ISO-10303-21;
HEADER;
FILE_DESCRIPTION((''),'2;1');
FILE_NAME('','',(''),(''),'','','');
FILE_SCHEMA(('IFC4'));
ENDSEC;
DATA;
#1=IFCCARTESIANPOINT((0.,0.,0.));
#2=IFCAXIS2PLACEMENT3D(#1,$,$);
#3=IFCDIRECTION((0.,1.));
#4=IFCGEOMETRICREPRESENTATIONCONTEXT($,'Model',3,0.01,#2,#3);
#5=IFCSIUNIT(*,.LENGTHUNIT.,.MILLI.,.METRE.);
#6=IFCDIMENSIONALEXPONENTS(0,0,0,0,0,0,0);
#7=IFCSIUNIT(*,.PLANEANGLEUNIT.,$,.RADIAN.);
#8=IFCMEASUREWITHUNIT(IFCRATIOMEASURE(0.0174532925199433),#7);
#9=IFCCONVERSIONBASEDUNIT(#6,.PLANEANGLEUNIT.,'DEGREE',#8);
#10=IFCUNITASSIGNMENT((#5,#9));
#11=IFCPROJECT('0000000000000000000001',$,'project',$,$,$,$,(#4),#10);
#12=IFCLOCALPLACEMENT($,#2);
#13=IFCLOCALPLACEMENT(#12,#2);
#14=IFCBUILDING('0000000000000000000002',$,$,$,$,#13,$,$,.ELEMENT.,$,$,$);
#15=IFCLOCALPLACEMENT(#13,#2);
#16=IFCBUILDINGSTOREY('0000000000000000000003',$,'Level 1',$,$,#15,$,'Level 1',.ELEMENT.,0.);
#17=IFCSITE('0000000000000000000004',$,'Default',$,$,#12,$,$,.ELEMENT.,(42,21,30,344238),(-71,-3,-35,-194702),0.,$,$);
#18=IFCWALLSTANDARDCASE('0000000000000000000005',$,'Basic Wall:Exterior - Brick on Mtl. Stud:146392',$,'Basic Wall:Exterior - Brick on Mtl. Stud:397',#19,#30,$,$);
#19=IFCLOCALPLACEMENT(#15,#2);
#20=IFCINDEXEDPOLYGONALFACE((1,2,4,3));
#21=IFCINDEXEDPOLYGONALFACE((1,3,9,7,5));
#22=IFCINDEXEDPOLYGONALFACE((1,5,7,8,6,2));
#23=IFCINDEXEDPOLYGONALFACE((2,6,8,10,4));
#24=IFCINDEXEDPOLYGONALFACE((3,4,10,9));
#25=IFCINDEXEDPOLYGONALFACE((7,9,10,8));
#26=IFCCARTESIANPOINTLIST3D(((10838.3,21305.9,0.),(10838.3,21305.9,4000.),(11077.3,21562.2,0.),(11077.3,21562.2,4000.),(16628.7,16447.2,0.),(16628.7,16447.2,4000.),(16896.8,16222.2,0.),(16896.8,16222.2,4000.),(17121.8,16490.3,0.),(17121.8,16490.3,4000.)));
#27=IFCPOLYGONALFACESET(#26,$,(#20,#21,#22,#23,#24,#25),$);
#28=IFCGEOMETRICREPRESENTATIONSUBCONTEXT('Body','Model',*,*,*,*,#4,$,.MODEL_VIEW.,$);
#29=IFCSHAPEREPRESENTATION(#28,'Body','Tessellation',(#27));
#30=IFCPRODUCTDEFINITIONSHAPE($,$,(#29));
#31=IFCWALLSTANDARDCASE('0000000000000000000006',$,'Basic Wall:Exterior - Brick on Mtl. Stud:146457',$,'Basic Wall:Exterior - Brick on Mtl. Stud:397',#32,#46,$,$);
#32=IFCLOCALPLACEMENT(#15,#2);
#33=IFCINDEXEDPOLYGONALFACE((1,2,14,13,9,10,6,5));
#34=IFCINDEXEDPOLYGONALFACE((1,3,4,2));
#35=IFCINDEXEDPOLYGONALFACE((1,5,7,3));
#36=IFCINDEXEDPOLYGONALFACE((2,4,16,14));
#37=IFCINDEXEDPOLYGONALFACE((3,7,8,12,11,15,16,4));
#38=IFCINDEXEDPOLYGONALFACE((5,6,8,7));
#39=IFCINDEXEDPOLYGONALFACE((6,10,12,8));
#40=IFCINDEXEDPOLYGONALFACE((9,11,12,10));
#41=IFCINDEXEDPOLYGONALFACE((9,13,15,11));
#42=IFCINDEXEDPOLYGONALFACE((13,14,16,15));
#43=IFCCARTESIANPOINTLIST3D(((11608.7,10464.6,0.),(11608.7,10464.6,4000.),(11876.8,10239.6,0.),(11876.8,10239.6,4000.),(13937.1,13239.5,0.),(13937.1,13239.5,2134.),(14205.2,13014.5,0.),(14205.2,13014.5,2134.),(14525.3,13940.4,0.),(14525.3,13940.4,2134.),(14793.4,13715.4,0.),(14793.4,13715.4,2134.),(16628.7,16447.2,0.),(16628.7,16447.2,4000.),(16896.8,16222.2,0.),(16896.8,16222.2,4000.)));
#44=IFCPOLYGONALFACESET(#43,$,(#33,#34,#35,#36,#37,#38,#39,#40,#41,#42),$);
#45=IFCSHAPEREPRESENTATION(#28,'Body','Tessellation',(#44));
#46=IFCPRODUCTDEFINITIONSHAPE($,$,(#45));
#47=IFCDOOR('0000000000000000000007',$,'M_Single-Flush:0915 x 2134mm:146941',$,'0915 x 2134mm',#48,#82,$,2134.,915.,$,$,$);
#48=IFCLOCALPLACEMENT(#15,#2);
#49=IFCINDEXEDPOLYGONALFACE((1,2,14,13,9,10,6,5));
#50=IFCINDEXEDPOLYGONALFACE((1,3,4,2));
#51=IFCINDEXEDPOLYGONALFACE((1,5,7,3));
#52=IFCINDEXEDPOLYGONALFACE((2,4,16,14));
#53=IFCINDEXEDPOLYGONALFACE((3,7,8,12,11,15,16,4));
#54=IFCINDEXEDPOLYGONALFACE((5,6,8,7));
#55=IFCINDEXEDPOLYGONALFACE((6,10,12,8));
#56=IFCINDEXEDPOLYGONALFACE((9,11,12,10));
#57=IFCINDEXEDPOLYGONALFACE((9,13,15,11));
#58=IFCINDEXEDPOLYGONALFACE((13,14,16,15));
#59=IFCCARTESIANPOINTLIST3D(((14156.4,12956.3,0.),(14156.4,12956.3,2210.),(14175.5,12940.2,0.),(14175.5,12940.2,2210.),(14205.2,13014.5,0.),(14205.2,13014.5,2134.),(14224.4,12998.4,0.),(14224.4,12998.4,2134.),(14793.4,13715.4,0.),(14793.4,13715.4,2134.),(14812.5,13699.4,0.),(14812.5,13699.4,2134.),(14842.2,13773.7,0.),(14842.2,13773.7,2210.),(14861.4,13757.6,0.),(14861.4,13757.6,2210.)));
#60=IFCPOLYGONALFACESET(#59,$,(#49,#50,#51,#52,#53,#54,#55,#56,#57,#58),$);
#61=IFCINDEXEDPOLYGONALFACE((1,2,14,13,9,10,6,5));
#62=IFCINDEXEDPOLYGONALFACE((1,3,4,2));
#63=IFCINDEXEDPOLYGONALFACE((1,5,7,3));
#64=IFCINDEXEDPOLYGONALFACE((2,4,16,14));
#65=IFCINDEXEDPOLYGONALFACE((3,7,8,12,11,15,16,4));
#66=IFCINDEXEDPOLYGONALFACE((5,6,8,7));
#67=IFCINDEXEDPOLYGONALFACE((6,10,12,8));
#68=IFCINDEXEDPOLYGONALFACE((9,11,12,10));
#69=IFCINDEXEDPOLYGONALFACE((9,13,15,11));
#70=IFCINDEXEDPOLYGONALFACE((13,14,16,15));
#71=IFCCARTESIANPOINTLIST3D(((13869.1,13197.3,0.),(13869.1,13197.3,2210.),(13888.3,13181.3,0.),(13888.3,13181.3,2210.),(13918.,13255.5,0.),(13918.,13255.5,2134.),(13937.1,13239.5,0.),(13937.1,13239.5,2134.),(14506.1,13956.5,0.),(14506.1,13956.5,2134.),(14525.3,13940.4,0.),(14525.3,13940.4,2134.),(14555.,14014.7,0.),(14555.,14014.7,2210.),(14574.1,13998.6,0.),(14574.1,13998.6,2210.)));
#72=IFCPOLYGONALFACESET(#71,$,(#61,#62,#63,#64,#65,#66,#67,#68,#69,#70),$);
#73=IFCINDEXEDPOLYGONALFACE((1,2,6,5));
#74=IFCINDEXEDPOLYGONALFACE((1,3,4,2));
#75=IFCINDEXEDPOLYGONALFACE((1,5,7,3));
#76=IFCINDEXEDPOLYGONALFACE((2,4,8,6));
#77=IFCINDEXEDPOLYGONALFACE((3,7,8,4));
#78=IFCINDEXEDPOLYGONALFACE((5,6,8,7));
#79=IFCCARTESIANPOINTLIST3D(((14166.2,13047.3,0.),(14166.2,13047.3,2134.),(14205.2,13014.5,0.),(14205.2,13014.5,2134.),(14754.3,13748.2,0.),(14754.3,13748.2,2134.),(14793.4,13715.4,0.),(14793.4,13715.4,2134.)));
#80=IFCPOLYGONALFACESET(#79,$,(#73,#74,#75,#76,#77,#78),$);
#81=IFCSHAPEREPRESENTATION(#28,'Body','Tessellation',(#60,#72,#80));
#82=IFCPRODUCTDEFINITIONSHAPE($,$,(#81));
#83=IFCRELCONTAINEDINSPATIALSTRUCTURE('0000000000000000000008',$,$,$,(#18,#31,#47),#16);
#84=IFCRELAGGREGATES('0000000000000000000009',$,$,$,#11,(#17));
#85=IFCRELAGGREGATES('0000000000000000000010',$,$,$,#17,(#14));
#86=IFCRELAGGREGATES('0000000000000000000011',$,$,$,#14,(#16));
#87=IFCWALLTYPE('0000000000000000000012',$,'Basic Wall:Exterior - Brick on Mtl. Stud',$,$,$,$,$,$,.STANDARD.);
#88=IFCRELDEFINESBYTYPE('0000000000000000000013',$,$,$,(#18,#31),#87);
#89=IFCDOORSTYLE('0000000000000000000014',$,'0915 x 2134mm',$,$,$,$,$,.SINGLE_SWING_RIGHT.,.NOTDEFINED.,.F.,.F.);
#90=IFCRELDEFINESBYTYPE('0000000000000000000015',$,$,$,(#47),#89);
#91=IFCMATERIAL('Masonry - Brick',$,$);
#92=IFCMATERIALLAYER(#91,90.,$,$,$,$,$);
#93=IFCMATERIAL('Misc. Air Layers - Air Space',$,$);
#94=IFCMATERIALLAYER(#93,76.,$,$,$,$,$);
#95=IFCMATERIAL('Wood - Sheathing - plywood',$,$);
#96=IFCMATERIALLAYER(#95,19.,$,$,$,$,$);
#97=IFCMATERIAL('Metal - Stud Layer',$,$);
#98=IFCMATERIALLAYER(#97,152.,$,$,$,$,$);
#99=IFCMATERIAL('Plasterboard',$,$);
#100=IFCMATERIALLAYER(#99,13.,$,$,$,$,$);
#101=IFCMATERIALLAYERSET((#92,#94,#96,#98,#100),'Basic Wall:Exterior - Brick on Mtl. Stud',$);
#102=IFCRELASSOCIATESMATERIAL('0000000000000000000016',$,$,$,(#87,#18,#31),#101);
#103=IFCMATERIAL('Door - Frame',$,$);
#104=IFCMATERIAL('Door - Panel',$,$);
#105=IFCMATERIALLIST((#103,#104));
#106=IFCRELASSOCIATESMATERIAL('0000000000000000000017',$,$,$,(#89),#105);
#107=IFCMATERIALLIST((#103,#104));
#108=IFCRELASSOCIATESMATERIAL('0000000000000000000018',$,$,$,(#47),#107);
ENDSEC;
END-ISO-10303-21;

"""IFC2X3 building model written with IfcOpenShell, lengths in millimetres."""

from ifc_helpers import new_model, entity, si_unit, converted_unit, direction, frame, frame_2d, origin, place, context, subcontext, project, spatial, polyline, rectangle, outline, extrude, source, transform, mapped, material, material_list, layer, layer_set, layer_usage, type_object, type_shapes, element, fill, save


model = new_model("IFC2X3")

# Units and contexts
model_context = context("Model", 3, precision=0.01, world=origin(), true_north=direction((0.0, 1.0)))
body_context = subcontext(model_context, "Body", "Model", "MODEL_VIEW")
ifc_project = project(units=[si_unit("LENGTHUNIT", "METRE", prefix="MILLI"), converted_unit("PLANEANGLEUNIT", "DEGREE", entity("IfcRatioMeasure", 0.0174532925199433), si_unit("PLANEANGLEUNIT", "RADIAN"), dimensions=[0, 0, 0, 0, 0, 0, 0])], contexts=[model_context])

# Site, building, storey
site_placement = place(None, origin())
site = spatial("IfcSite", under=ifc_project, at=site_placement, Name="Default", CompositionType="ELEMENT", RefLatitude=(42, 21, 30, 344238), RefLongitude=(-71, -3, -35, -194702), RefElevation=0.0)
building_placement = place(site_placement, origin())
building = spatial("IfcBuilding", under=site, at=building_placement, CompositionType="ELEMENT")
storey_placement = place(building_placement, origin())
storey = spatial("IfcBuildingStorey", under=building, at=storey_placement, Name="Level 1", LongName="Level 1", CompositionType="ELEMENT", Elevation=0.0)

# Wall
ifc_material_1 = material(Name="Masonry - Brick")
ifc_layer_1 = layer(ifc_material_1, 90.0)
ifc_material_2 = material(Name="Misc. Air Layers - Air Space")
ifc_layer_2 = layer(ifc_material_2, 76.0)
ifc_material_3 = material(Name="Wood - Sheathing - plywood")
ifc_layer_3 = layer(ifc_material_3, 19.0)
ifc_material_4 = material(Name="Metal - Stud Layer")
ifc_layer_4 = layer(ifc_material_4, 152.0)
ifc_material_5 = material(Name="Plasterboard")
ifc_layer_5 = layer(ifc_material_5, 13.0)
ifc_layer_set = layer_set([ifc_layer_1, ifc_layer_2, ifc_layer_3, ifc_layer_4, ifc_layer_5], Name="Basic Wall:Exterior - Brick on Mtl. Stud")
ifc_layer_usage_1 = layer_usage(ifc_layer_set, "AXIS2", "NEGATIVE", 175.0)
wall_type = type_object("IfcWallType", Name="Basic Wall:Exterior - Brick on Mtl. Stud", PredefinedType="STANDARD", material=ifc_layer_set)
wall_1_placement = place(storey_placement, frame((10950.8, 21439.9, 0.0), z_axis=(0.0, 0.0, 1.0), x_axis=(0.766044, -0.642788, 0.0)))
element("IfcWallStandardCase", 1, at=wall_1_placement, inside=storey, type_object=wall_type, material=ifc_layer_usage_1, Name="Basic Wall:Exterior - Brick on Mtl. Stud:146392", ObjectType="Basic Wall:Exterior - Brick on Mtl. Stud:397", context=body_context, shape_type="SweptSolid", body=[
    extrude(outline(polyline([(7908.8, -175.0), (7908.8, 175.0), (18.3, 175.0), (0.0, -175.0), (7558.8, -175.0), (7908.8, -175.0)])), origin(), (0.0, 0.0, 1.0), 4000.0),
])

# Wall, opening, door
ifc_layer_usage_2 = layer_usage(ifc_layer_set, "AXIS2", "NEGATIVE", 175.0)
wall_2_placement = place(storey_placement, frame((16762.7, 16334.7, 0.0), z_axis=(0.0, 0.0, 1.0), x_axis=(-0.642788, -0.766044, 0.0)))
wall_2 = element("IfcWallStandardCase", 2, at=wall_2_placement, inside=storey, type_object=wall_type, material=ifc_layer_usage_2, Name="Basic Wall:Exterior - Brick on Mtl. Stud:146457", ObjectType="Basic Wall:Exterior - Brick on Mtl. Stud:397", context=body_context, shape_type="SweptSolid", body=[
    extrude(rectangle(XDim=7809.7, YDim=350.0, at=frame_2d((3904.8, 0.0), x_axis=(-1.0, 0.0))), origin(), (0.0, 0.0, 1.0), 4000.0),
])
opening_1_placement = place(wall_2_placement, frame((3272.3, -175.0, 0.0)))
opening_1 = element("IfcOpeningElement", 3, at=opening_1_placement, cuts=wall_2, ObjectType="Opening", context=body_context, shape_type="SweptSolid", body=[
    extrude(rectangle(XDim=915.0, YDim=2134.0, at=frame_2d((1067.0, 457.5), x_axis=(0.0, 1.0))), frame((0.0, 0.0, 0.0), z_axis=(0.0, 1.0, 0.0), x_axis=(0.0, 0.0, 1.0)), (0.0, 0.0, 1.0), 350.0),
])
ifc_material_6 = material(Name="Door - Frame")
ifc_material_7 = material(Name="Door - Panel")
ifc_material_list_1 = material_list([ifc_material_6, ifc_material_7])
ifc_material_list_2 = material_list([ifc_material_6, ifc_material_7])
door_style = type_object("IfcDoorStyle", Name="0915 x 2134mm", ConstructionType="NOTDEFINED", OperationType="SINGLE_SWING_RIGHT", ParameterTakesPrecedence=False, Sizeable=False, material=ifc_material_list_2)
shared_shape_1 = source(origin(), body_context, "Body", "SweptSolid", [
    extrude(outline(polyline([(-533.5, -1124.0), (533.5, -1124.0), (533.5, 1086.0), (457.5, 1086.0), (457.5, -1048.0), (-457.5, -1048.0), (-457.5, 1086.0), (-533.5, 1086.0), (-533.5, -1124.0)])), frame((457.5, 350.0, 1086.0), z_axis=(0.0, 1.0, 0.0), x_axis=(1.0, 0.0, 0.0)), (0.0, 0.0, 1.0), 25.0),
    extrude(outline(polyline([(-1124.0, -533.5), (1086.0, -533.5), (1086.0, -457.5), (-1048.0, -457.5), (-1048.0, 457.5), (1086.0, 457.5), (1086.0, 533.5), (-1124.0, 533.5), (-1124.0, -533.5)])), frame((457.5, -25.0, 1086.0), z_axis=(0.0, 1.0, 0.0), x_axis=(0.0, 0.0, -1.0)), (0.0, 0.0, 1.0), 25.0),
    extrude(rectangle(XDim=51.0, YDim=915.0, at=frame_2d((0.0, 0.0), x_axis=(1.0, 0.0))), frame((457.5, 324.5, 0.0), z_axis=(0.0, 0.0, 1.0), x_axis=(0.0, 1.0, 0.0)), (0.0, 0.0, 1.0), 2134.0),
])
type_shapes(door_style, [shared_shape_1])
door_placement = place(opening_1_placement, origin())
door = element("IfcDoor", 4, at=door_placement, inside=storey, type_object=door_style, material=ifc_material_list_1, Name="M_Single-Flush:0915 x 2134mm:146941", ObjectType="0915 x 2134mm", OverallHeight=2134.0, OverallWidth=915.0, context=body_context, shape_type="MappedRepresentation", body=[
    mapped(shared_shape_1, transform((0.0, 0.0, 0.0), scale=1.0)),
])
fill(opening_1, door)

save(model, "model.ifc")
